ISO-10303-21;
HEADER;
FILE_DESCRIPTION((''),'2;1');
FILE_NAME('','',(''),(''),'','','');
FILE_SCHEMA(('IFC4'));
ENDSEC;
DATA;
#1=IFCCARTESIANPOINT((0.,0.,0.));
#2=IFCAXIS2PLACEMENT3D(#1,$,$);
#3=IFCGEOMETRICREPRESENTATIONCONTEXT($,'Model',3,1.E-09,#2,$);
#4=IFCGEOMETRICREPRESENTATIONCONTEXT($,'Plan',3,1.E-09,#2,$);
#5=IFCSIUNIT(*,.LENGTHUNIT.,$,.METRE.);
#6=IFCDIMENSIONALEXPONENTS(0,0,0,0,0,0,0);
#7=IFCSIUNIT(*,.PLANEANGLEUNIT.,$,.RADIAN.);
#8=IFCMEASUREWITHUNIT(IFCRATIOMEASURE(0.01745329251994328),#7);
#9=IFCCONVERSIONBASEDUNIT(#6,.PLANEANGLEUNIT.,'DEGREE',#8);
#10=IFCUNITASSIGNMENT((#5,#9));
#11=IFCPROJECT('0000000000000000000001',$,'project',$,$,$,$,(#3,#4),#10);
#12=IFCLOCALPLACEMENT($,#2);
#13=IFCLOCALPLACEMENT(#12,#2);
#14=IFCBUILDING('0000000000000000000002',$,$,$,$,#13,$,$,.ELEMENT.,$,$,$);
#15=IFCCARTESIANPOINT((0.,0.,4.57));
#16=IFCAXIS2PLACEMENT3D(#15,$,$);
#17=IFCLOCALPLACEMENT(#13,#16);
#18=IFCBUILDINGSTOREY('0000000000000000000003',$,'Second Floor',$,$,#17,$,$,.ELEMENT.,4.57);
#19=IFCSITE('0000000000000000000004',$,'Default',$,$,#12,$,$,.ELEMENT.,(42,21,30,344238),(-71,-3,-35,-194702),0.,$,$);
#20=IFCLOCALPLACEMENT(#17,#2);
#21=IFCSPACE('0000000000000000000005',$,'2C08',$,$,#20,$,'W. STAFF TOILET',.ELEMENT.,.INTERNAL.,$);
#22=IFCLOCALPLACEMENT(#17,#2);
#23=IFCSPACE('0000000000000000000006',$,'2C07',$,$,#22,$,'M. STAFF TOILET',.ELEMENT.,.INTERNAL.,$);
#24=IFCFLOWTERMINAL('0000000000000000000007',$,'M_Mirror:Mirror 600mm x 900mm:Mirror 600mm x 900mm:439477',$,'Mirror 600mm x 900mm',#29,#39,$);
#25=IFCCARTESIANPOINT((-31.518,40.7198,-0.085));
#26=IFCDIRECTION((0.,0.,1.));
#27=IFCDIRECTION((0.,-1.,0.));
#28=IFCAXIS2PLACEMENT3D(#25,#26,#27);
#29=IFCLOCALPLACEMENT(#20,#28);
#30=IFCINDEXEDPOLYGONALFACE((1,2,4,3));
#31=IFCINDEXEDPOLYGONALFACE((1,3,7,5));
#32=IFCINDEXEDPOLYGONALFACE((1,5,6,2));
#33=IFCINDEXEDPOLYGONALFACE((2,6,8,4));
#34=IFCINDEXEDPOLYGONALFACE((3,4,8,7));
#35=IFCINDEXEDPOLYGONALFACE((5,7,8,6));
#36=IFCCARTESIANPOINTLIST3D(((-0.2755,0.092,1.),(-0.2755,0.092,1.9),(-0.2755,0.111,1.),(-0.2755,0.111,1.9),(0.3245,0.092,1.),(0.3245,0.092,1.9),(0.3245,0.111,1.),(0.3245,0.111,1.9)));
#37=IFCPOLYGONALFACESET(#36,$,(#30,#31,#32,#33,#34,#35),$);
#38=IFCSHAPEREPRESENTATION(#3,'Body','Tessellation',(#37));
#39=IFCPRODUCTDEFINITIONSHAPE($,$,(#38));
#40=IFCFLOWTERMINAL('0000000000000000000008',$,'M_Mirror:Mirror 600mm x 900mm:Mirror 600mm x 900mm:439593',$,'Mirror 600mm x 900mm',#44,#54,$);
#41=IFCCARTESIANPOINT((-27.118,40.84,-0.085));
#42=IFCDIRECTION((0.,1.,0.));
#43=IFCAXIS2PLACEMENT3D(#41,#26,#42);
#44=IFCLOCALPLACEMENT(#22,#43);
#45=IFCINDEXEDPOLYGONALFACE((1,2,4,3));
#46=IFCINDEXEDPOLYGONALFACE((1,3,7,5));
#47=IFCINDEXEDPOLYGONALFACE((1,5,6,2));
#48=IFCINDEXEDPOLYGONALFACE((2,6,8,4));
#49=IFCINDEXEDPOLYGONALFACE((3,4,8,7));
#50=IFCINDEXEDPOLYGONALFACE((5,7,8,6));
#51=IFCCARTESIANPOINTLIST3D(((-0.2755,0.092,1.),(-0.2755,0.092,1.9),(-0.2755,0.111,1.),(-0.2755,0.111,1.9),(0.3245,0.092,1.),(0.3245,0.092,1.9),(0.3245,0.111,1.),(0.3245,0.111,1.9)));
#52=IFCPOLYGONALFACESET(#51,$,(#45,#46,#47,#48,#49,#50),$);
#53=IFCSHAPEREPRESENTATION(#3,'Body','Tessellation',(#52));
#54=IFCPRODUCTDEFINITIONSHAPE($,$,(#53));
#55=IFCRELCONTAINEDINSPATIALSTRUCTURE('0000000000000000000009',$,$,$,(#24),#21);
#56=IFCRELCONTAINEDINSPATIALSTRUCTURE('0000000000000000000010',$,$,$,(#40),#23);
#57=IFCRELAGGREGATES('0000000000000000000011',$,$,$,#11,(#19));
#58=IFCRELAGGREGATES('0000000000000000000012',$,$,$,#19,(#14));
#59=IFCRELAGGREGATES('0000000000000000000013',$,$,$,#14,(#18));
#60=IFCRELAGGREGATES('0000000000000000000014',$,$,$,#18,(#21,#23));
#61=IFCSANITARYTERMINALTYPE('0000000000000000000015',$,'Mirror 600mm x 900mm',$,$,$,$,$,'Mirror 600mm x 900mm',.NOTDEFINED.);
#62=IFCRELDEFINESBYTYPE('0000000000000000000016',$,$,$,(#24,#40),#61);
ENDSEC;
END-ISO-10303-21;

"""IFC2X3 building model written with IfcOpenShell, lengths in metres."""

from ifc_helpers import new_model, entity, si_unit, converted_unit, frame, origin, origin_2d_with_axis, place, context, project, spatial, rectangle, extrude, source, transform, mapped, type_object, type_shapes, element, save


model = new_model("IFC2X3")

# Units and contexts
model_context = context("Model", 3, precision=1e-09, world=origin())
plan_context = context("Plan", 3, precision=1e-09, world=origin())
ifc_project = project(units=[si_unit("LENGTHUNIT", "METRE"), converted_unit("PLANEANGLEUNIT", "DEGREE", entity("IfcRatioMeasure", 0.01745329251994328), si_unit("PLANEANGLEUNIT", "RADIAN"), dimensions=[0, 0, 0, 0, 0, 0, 0])], contexts=[model_context, plan_context])

# Site, building, storey
site_placement = place(None, origin())
site = spatial("IfcSite", under=ifc_project, at=site_placement, Name="Default", CompositionType="ELEMENT", RefLatitude=(42, 21, 30, 344238), RefLongitude=(-71, -3, -35, -194702), RefElevation=0.0)
building_placement = place(site_placement, origin())
building = spatial("IfcBuilding", under=site, at=building_placement, CompositionType="ELEMENT")
storey_placement = place(building_placement, frame((0.0, 0.0, 4.57)))
storey = spatial("IfcBuildingStorey", under=building, at=storey_placement, Name="Second Floor", CompositionType="ELEMENT", Elevation=4.57)

# Shared definitions
space_1_placement = place(storey_placement, origin())
space_1 = spatial("IfcSpace", under=storey, at=space_1_placement, Name="2C08", LongName="W. STAFF TOILET", CompositionType="ELEMENT", InteriorOrExteriorSpace="INTERNAL")

# Flow terminal
sanitary_terminal_type = type_object("IfcSanitaryTerminalType", Name="Mirror 600mm x 900mm", ElementType="Mirror 600mm x 900mm", PredefinedType="NOTDEFINED")
shared_shape_1 = source(origin(), model_context, "Body", "SweptSolid", [
    extrude(rectangle(XDim=0.0191, YDim=0.6, at=origin_2d_with_axis()), frame((0.0245, 0.1015, 1.0), z_axis=(0.0, 0.0, 1.0), x_axis=(0.0, -1.0, 0.0)), (0.0, 0.0, 1.0), 0.9),
])
type_shapes(sanitary_terminal_type, [shared_shape_1])
flow_terminal_1_placement = place(space_1_placement, frame((-31.518, 40.7198, -0.085), z_axis=(0.0, 0.0, 1.0), x_axis=(0.0, -1.0, 0.0)))
element("IfcFlowTerminal", 1, at=flow_terminal_1_placement, inside=space_1, type_object=sanitary_terminal_type, Name="M_Mirror:Mirror 600mm x 900mm:Mirror 600mm x 900mm:439477", ObjectType="Mirror 600mm x 900mm", context=model_context, shape_type="MappedRepresentation", body=[
    mapped(shared_shape_1, transform((0.0, 0.0, 0.0), scale=1.0)),
])

# Shared definitions
space_2_placement = place(storey_placement, origin())
space_2 = spatial("IfcSpace", under=storey, at=space_2_placement, Name="2C07", LongName="M. STAFF TOILET", CompositionType="ELEMENT", InteriorOrExteriorSpace="INTERNAL")

# Flow terminal
flow_terminal_2_placement = place(space_2_placement, frame((-27.118, 40.84, -0.085), z_axis=(0.0, 0.0, 1.0), x_axis=(0.0, 1.0, 0.0)))
element("IfcFlowTerminal", 2, at=flow_terminal_2_placement, inside=space_2, type_object=sanitary_terminal_type, Name="M_Mirror:Mirror 600mm x 900mm:Mirror 600mm x 900mm:439593", ObjectType="Mirror 600mm x 900mm", context=model_context, shape_type="MappedRepresentation", body=[
    mapped(shared_shape_1, transform((0.0, 0.0, 0.0), scale=1.0)),
])

save(model, "model.ifc")
